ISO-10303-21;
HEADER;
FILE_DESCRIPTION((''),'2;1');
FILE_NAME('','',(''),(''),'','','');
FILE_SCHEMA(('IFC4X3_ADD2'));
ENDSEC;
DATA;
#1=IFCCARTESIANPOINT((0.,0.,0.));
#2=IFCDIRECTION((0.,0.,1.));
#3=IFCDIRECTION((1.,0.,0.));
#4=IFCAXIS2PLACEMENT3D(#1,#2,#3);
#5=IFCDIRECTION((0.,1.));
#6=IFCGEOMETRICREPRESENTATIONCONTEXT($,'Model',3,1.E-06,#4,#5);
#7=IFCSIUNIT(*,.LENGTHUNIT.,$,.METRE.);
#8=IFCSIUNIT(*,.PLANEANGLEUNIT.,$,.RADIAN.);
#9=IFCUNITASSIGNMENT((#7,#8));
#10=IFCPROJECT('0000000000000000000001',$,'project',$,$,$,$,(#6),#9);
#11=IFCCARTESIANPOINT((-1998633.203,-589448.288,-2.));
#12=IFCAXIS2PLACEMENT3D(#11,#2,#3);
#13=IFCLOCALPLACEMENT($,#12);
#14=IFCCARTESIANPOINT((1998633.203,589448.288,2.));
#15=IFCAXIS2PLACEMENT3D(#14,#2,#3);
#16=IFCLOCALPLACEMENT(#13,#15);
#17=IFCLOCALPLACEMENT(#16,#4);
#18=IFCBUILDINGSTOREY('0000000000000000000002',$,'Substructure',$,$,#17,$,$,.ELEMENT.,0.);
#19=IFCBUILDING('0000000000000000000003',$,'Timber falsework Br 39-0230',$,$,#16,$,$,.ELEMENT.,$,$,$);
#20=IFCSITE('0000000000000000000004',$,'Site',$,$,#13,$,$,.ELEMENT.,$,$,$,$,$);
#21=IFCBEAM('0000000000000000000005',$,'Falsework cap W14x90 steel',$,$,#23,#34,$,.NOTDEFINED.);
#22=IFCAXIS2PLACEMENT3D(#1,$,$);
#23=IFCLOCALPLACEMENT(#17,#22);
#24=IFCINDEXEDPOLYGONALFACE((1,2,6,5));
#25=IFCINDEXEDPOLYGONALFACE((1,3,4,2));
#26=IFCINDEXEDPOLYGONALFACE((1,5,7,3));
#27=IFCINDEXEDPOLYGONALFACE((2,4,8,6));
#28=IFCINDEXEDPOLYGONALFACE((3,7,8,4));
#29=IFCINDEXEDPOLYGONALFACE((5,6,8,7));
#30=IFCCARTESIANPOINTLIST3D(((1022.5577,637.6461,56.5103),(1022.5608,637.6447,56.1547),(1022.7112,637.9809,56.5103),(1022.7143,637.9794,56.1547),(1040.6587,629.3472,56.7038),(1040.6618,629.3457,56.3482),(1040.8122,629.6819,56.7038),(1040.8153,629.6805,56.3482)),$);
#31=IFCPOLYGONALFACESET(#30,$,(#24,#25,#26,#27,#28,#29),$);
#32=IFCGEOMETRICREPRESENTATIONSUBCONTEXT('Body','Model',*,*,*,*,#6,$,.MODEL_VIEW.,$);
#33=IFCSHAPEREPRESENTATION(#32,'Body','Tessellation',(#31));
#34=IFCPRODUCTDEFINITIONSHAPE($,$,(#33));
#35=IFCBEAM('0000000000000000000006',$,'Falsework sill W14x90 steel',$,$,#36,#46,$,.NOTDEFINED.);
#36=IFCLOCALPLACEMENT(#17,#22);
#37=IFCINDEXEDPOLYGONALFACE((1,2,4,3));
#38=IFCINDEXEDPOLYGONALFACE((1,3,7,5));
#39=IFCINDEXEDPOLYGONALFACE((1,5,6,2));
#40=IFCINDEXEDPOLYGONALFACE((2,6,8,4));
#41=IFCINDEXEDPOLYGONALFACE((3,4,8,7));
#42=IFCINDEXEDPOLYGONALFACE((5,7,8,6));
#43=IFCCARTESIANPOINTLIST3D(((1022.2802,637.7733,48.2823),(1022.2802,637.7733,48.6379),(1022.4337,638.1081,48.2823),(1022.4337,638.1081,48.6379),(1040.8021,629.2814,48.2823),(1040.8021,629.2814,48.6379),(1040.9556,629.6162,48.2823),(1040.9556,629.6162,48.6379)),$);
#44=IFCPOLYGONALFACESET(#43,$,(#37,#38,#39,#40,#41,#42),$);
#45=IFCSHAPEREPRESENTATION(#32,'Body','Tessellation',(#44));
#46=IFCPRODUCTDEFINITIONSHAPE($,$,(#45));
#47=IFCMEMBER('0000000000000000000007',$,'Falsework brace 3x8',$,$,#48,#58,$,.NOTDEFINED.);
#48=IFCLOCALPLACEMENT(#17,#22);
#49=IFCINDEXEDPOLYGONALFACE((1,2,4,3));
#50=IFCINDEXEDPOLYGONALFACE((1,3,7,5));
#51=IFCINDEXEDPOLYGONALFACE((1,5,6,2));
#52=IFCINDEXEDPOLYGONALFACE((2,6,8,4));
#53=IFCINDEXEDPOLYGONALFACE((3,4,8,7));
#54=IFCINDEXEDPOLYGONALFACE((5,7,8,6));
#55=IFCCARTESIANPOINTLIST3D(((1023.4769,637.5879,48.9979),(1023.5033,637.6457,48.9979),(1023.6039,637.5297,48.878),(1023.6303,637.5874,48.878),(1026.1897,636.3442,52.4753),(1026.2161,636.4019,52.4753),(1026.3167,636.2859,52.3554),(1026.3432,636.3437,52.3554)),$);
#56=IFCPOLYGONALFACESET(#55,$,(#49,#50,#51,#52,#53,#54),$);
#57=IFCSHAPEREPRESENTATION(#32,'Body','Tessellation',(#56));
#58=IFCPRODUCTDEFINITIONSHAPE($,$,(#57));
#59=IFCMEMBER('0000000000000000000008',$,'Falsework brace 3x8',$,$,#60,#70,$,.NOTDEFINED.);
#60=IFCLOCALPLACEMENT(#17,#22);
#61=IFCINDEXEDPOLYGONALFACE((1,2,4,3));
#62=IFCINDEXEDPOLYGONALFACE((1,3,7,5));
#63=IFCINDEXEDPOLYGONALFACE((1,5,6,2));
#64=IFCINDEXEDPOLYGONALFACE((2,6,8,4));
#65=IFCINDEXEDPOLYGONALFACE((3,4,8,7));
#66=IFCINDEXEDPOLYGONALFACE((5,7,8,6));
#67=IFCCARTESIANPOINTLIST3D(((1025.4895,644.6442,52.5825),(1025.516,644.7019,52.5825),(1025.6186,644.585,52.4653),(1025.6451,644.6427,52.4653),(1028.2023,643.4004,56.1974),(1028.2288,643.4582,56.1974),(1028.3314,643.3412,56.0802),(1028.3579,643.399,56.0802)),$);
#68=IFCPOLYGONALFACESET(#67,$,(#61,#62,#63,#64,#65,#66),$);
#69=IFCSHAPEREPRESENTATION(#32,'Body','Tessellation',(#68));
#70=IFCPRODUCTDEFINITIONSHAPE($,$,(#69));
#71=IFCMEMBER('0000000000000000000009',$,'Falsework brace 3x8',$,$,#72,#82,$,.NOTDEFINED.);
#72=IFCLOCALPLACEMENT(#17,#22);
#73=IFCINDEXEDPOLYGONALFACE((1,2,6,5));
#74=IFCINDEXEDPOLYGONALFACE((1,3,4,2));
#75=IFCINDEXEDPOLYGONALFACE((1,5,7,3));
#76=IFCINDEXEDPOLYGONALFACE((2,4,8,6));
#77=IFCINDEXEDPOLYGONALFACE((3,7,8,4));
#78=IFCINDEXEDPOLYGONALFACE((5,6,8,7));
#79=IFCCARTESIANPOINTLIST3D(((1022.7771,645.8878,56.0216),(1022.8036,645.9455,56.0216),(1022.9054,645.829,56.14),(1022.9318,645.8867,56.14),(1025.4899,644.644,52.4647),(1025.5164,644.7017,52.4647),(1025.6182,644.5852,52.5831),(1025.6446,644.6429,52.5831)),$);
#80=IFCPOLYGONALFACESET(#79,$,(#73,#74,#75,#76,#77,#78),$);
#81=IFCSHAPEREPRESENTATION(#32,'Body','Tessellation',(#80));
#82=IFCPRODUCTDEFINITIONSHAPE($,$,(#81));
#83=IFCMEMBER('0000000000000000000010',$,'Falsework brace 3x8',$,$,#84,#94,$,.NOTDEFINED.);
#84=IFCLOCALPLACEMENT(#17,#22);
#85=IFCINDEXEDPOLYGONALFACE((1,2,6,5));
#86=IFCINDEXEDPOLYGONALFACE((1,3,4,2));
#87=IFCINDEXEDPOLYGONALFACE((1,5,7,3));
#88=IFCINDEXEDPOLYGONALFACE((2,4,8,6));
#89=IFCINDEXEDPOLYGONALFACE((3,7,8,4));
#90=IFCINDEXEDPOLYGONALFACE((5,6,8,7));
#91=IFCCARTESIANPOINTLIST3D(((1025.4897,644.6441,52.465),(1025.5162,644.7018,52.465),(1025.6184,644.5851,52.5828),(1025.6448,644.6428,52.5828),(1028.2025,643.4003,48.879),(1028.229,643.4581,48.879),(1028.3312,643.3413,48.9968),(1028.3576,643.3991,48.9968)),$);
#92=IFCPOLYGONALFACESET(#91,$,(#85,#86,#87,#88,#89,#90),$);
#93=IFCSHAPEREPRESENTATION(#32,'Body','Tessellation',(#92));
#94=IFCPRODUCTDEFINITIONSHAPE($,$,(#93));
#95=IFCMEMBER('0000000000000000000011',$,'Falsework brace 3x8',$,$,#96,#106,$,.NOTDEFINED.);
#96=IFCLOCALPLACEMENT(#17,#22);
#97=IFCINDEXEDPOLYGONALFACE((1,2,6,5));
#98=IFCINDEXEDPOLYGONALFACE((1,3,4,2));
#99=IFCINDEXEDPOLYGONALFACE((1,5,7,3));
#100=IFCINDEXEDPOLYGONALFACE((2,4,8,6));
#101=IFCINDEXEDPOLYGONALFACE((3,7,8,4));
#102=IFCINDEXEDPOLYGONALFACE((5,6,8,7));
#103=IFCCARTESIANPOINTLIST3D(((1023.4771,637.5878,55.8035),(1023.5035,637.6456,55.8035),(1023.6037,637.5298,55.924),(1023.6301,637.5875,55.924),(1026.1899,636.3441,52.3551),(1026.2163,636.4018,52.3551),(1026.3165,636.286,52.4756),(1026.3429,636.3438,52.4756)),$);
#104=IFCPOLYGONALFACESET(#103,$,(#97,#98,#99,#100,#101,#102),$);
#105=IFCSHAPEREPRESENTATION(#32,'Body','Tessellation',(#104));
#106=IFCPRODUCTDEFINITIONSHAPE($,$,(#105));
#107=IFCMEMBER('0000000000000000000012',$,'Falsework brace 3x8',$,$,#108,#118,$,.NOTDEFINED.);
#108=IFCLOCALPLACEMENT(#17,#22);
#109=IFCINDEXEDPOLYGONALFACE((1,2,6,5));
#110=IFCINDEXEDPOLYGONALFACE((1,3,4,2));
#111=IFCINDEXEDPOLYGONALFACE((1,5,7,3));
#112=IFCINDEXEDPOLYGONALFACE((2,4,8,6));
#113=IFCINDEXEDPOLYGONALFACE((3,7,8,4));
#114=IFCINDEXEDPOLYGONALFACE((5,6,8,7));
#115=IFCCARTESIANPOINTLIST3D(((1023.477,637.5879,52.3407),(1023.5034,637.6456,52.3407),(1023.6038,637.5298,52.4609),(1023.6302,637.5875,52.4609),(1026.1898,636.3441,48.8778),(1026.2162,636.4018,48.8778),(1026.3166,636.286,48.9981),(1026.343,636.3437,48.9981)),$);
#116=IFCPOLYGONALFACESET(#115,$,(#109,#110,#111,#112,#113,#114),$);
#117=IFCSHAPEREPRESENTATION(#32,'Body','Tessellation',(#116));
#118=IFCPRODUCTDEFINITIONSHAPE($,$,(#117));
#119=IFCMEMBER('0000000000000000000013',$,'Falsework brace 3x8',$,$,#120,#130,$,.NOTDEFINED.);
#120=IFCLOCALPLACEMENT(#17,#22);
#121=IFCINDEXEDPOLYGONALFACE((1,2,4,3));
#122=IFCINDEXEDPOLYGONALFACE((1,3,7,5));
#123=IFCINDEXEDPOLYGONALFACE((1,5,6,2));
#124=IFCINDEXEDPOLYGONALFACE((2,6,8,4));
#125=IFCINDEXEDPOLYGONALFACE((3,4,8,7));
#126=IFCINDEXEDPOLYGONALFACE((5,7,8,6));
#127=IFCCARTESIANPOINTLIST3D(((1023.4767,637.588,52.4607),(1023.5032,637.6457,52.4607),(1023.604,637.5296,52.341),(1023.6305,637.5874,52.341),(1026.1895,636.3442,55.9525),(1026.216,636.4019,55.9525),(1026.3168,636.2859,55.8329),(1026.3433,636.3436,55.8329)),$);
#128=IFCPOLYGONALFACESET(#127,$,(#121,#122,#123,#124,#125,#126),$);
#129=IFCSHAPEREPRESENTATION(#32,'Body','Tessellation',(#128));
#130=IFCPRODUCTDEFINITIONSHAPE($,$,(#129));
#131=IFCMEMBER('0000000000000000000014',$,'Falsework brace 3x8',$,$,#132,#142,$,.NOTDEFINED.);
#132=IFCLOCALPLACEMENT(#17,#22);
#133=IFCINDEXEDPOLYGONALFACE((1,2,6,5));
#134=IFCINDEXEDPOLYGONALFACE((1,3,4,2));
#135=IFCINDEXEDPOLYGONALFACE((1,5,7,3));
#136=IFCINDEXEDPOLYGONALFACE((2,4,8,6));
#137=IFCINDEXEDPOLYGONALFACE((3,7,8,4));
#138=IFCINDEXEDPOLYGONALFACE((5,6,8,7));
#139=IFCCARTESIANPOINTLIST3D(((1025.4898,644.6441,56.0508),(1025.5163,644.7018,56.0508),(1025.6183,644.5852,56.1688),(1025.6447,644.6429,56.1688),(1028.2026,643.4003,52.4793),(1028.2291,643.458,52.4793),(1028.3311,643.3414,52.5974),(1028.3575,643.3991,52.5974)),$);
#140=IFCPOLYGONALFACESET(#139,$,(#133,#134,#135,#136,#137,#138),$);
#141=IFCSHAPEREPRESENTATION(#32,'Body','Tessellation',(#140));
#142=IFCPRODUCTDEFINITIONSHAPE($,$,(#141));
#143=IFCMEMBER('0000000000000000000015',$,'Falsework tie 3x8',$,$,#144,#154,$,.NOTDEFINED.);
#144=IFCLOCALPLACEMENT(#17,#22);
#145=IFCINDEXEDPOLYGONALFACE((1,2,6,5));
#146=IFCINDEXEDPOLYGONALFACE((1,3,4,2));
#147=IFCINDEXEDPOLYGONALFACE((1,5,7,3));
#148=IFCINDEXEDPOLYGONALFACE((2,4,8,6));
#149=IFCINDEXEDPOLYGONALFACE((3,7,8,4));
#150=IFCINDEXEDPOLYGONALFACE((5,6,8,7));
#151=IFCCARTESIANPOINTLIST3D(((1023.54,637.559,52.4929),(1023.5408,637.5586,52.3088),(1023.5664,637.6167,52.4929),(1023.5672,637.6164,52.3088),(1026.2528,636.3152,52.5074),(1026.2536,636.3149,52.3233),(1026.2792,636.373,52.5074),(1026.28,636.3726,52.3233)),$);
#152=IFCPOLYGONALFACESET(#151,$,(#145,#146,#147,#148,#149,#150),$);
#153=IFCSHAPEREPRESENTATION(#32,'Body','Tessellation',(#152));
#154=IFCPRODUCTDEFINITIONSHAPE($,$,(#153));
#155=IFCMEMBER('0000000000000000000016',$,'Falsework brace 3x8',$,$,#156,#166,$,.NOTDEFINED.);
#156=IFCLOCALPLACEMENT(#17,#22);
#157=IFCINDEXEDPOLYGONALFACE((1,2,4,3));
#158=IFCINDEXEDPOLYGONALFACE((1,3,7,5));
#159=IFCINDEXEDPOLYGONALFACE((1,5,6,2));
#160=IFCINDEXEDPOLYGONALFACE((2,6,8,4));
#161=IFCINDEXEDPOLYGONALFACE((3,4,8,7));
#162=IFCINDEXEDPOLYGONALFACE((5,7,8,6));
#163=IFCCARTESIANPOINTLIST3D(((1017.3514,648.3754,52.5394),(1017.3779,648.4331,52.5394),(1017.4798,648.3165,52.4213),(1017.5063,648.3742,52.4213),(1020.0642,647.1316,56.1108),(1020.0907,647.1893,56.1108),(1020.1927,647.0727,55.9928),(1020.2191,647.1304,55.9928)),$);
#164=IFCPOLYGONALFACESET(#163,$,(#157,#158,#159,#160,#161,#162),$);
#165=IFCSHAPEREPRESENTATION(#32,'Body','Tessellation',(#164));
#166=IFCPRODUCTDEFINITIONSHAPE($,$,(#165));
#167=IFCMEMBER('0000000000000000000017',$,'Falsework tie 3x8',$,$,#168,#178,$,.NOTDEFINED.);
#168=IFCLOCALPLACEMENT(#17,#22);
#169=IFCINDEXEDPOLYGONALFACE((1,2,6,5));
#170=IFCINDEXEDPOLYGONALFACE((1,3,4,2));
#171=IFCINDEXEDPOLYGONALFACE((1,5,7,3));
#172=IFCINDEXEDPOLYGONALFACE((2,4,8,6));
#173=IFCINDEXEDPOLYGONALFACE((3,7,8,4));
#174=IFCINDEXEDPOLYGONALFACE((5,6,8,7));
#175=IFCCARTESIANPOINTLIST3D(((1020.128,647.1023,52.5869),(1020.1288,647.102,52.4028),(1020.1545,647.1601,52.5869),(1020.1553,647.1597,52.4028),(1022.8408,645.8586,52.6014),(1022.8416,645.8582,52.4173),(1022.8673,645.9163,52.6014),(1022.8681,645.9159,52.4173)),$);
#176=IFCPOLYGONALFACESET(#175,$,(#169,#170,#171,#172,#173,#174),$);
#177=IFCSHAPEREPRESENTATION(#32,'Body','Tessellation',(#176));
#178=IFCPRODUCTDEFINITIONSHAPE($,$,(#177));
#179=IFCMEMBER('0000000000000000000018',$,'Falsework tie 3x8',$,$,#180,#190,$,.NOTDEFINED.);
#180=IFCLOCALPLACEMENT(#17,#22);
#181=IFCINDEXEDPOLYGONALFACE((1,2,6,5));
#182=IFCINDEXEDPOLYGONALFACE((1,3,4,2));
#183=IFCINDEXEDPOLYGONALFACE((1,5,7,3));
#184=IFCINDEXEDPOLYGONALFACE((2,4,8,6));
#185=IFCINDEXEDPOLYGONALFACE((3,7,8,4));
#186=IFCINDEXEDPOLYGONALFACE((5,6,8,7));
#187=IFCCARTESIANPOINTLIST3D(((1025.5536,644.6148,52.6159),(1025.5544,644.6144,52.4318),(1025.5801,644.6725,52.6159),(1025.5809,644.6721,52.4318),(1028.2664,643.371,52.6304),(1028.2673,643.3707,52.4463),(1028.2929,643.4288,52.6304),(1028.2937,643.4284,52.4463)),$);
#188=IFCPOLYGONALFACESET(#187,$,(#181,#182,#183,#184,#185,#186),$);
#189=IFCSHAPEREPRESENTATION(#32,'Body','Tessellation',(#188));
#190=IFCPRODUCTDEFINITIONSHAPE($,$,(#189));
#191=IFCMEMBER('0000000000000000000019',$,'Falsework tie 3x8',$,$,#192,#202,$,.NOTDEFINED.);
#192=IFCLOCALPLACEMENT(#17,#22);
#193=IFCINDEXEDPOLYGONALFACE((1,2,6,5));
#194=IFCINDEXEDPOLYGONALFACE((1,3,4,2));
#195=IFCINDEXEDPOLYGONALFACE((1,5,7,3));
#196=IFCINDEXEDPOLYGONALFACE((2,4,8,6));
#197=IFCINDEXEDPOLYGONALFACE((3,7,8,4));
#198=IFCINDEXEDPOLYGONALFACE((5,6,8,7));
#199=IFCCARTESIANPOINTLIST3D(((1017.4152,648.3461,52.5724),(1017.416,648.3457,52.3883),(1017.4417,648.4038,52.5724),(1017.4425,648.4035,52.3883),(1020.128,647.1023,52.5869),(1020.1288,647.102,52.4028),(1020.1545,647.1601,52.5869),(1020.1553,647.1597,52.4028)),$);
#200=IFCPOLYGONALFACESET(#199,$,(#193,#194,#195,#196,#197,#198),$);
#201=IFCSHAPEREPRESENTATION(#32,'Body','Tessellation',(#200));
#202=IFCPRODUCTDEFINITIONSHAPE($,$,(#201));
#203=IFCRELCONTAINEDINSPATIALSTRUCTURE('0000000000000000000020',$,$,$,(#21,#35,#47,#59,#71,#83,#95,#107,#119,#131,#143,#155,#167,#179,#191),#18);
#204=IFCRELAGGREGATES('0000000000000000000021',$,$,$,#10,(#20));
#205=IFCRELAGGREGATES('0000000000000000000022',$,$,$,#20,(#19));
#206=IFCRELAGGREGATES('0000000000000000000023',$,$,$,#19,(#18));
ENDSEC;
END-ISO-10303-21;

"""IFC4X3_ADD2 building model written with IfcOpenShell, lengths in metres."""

from ifc_helpers import new_model, si_unit, direction, frame, frame_2d, origin, origin_with_axes, origin_2d, place, context, subcontext, project, spatial, rectangle, extrude, element, save


model = new_model("IFC4X3_ADD2")

# Units and contexts
model_context = context("Model", 3, precision=1e-06, world=origin_with_axes(), true_north=direction((0.0, 1.0)))
body_context = subcontext(model_context, "Body", "Model", "MODEL_VIEW")
ifc_project = project(units=[si_unit("LENGTHUNIT", "METRE"), si_unit("PLANEANGLEUNIT", "RADIAN")], contexts=[model_context])

# Site, building, storey
site_placement = place(None, frame((-1998633.203, -589448.288, -2.0), z_axis=(0.0, 0.0, 1.0), x_axis=(1.0, 0.0, 0.0)))
site = spatial("IfcSite", under=ifc_project, at=site_placement, Name="Site", CompositionType="ELEMENT")
building_placement = place(site_placement, frame((1998633.203, 589448.288, 2.0), z_axis=(0.0, 0.0, 1.0), x_axis=(1.0, 0.0, 0.0)))
building = spatial("IfcBuilding", under=site, at=building_placement, Name="Timber falsework Br 39-0230", CompositionType="ELEMENT")
storey_placement = place(building_placement, origin_with_axes())
storey = spatial("IfcBuildingStorey", under=building, at=storey_placement, Name="Substructure", CompositionType="ELEMENT", Elevation=0.0)

# Beams
beam_1_placement = place(storey_placement, frame((1022.6376, 637.8121, 56.1547), z_axis=(0.908971, -0.416746, 0.009717), x_axis=(0.416765, 0.909014, 0.0)))
element("IfcBeam", 1, at=beam_1_placement, inside=storey, Name="Falsework cap W14x90 steel", PredefinedType="NOTDEFINED", context=body_context, shape_type="SweptSolid", body=[
    extrude(rectangle(XDim=0.3683, YDim=0.3556, at=frame_2d((0.0, 0.1778))), origin(), (0.0, 0.0, 1.0), 19.9137),
])
beam_2_placement = place(storey_placement, frame((1022.357, 637.9407, 48.2823), z_axis=(0.909014, -0.416765, 0.0), x_axis=(0.416765, 0.909014, 0.0)))
element("IfcBeam", 2, at=beam_2_placement, inside=storey, Name="Falsework sill W14x90 steel", PredefinedType="NOTDEFINED", context=body_context, shape_type="SweptSolid", body=[
    extrude(rectangle(XDim=0.3683, YDim=0.3556, at=frame_2d((0.0, 0.1778))), origin(), (0.0, 0.0, 1.0), 20.3758),
])

# Members
member_1_placement = place(storey_placement, frame((1023.5536, 637.5877, 48.9379), z_axis=(0.592004, -0.271422, 0.758855), x_axis=(0.416765, 0.909014, 0.0)))
element("IfcMember", 3, at=member_1_placement, inside=storey, Name="Falsework brace 3x8", PredefinedType="NOTDEFINED", context=body_context, shape_type="SweptSolid", body=[
    extrude(rectangle(XDim=0.0635, YDim=0.1841, at=origin_2d()), origin(), (0.0, 0.0, 1.0), 4.5824),
])
member_2_placement = place(storey_placement, frame((1025.5673, 644.6435, 52.5239), z_axis=(0.578714, -0.265329, 0.771162), x_axis=(0.416765, 0.909014, 0.0)))
element("IfcMember", 4, at=member_2_placement, inside=storey, Name="Falsework brace 3x8", PredefinedType="NOTDEFINED", context=body_context, shape_type="SweptSolid", body=[
    extrude(rectangle(XDim=0.0635, YDim=0.1841, at=origin_2d()), origin(), (0.0, 0.0, 1.0), 4.6876),
])
member_3_placement = place(storey_placement, frame((1022.8545, 645.8872, 56.0808), z_axis=(0.584271, -0.267877, -0.766074), x_axis=(0.416765, 0.909014, 0.0)))
element("IfcMember", 5, at=member_3_placement, inside=storey, Name="Falsework brace 3x8", PredefinedType="NOTDEFINED", context=body_context, shape_type="SweptSolid", body=[
    extrude(rectangle(XDim=0.0635, YDim=0.1841, at=origin_2d()), origin(), (0.0, 0.0, 1.0), 4.6431),
])
member_4_placement = place(storey_placement, frame((1025.5673, 644.6435, 52.5239), z_axis=(0.581484, -0.266599, -0.768636), x_axis=(0.416765, 0.909014, 0.0)))
element("IfcMember", 6, at=member_4_placement, inside=storey, Name="Falsework brace 3x8", PredefinedType="NOTDEFINED", context=body_context, shape_type="SweptSolid", body=[
    extrude(rectangle(XDim=0.0635, YDim=0.1841, at=origin_2d()), origin(), (0.0, 0.0, 1.0), 4.6653),
])
member_5_placement = place(storey_placement, frame((1023.5536, 637.5877, 55.8637), z_axis=(0.594855, -0.27273, -0.756152), x_axis=(0.416765, 0.909014, 0.0)))
element("IfcMember", 7, at=member_5_placement, inside=storey, Name="Falsework brace 3x8", PredefinedType="NOTDEFINED", context=body_context, shape_type="SweptSolid", body=[
    extrude(rectangle(XDim=0.0635, YDim=0.1841, at=origin_2d()), origin(), (0.0, 0.0, 1.0), 4.5604),
])
member_6_placement = place(storey_placement, frame((1023.5536, 637.5877, 52.4008), z_axis=(0.593427, -0.272075, -0.757508), x_axis=(0.416765, 0.909014, 0.0)))
element("IfcMember", 8, at=member_6_placement, inside=storey, Name="Falsework brace 3x8", PredefinedType="NOTDEFINED", context=body_context, shape_type="SweptSolid", body=[
    extrude(rectangle(XDim=0.0635, YDim=0.1841, at=origin_2d()), origin(), (0.0, 0.0, 1.0), 4.5714),
])
member_7_placement = place(storey_placement, frame((1023.5536, 637.5877, 52.4008), z_axis=(0.590584, -0.270771, 0.760193), x_axis=(0.416765, 0.909014, 0.0)))
element("IfcMember", 9, at=member_7_placement, inside=storey, Name="Falsework brace 3x8", PredefinedType="NOTDEFINED", context=body_context, shape_type="SweptSolid", body=[
    extrude(rectangle(XDim=0.0635, YDim=0.1841, at=origin_2d()), origin(), (0.0, 0.0, 1.0), 4.5934),
])
member_8_placement = place(storey_placement, frame((1025.5673, 644.6435, 56.1098), z_axis=(0.582875, -0.267237, -0.76736), x_axis=(0.416765, 0.909014, 0.0)))
element("IfcMember", 10, at=member_8_placement, inside=storey, Name="Falsework brace 3x8", PredefinedType="NOTDEFINED", context=body_context, shape_type="SweptSolid", body=[
    extrude(rectangle(XDim=0.0635, YDim=0.1841, at=origin_2d()), origin(), (0.0, 0.0, 1.0), 4.6542),
])
member_9_placement = place(storey_placement, frame((1023.5536, 637.5877, 52.4008), z_axis=(0.909003, -0.41676, 0.004859), x_axis=(0.416765, 0.909014, 0.0)))
element("IfcMember", 11, at=member_9_placement, inside=storey, Name="Falsework tie 3x8", PredefinedType="NOTDEFINED", context=body_context, shape_type="SweptSolid", body=[
    extrude(rectangle(XDim=0.0635, YDim=0.1841, at=origin_2d()), origin(), (0.0, 0.0, 1.0), 2.9844),
])
member_10_placement = place(storey_placement, frame((1017.4289, 648.3748, 52.4804), z_axis=(0.582875, -0.267237, 0.76736), x_axis=(0.416765, 0.909014, 0.0)))
element("IfcMember", 12, at=member_10_placement, inside=storey, Name="Falsework brace 3x8", PredefinedType="NOTDEFINED", context=body_context, shape_type="SweptSolid", body=[
    extrude(rectangle(XDim=0.0635, YDim=0.1841, at=origin_2d()), origin(), (0.0, 0.0, 1.0), 4.6542),
])
for number, where, z_axis, x_axis, name in (
    (13, (1020.1417, 647.131, 52.4949), (0.909003, -0.41676, 0.004859), (0.416765, 0.909014, 0.0), "Falsework tie 3x8"),
    (14, (1025.5673, 644.6435, 52.5239), (0.909003, -0.41676, 0.004859), (0.416765, 0.909014, 0.0), "Falsework tie 3x8"),
    (15, (1017.4289, 648.3748, 52.4804), (0.909003, -0.41676, 0.004859), (0.416765, 0.909014, 0.0), "Falsework tie 3x8"),
):
    element("IfcMember", number, at=place(storey_placement, frame(where, z_axis=z_axis, x_axis=x_axis)), inside=storey, Name=name, PredefinedType="NOTDEFINED", context=body_context, shape_type="SweptSolid", body=[
        extrude(rectangle(XDim=0.0635, YDim=0.1841, at=origin_2d()), origin(), (0.0, 0.0, 1.0), 2.9844),
    ])

save(model, "model.ifc")
